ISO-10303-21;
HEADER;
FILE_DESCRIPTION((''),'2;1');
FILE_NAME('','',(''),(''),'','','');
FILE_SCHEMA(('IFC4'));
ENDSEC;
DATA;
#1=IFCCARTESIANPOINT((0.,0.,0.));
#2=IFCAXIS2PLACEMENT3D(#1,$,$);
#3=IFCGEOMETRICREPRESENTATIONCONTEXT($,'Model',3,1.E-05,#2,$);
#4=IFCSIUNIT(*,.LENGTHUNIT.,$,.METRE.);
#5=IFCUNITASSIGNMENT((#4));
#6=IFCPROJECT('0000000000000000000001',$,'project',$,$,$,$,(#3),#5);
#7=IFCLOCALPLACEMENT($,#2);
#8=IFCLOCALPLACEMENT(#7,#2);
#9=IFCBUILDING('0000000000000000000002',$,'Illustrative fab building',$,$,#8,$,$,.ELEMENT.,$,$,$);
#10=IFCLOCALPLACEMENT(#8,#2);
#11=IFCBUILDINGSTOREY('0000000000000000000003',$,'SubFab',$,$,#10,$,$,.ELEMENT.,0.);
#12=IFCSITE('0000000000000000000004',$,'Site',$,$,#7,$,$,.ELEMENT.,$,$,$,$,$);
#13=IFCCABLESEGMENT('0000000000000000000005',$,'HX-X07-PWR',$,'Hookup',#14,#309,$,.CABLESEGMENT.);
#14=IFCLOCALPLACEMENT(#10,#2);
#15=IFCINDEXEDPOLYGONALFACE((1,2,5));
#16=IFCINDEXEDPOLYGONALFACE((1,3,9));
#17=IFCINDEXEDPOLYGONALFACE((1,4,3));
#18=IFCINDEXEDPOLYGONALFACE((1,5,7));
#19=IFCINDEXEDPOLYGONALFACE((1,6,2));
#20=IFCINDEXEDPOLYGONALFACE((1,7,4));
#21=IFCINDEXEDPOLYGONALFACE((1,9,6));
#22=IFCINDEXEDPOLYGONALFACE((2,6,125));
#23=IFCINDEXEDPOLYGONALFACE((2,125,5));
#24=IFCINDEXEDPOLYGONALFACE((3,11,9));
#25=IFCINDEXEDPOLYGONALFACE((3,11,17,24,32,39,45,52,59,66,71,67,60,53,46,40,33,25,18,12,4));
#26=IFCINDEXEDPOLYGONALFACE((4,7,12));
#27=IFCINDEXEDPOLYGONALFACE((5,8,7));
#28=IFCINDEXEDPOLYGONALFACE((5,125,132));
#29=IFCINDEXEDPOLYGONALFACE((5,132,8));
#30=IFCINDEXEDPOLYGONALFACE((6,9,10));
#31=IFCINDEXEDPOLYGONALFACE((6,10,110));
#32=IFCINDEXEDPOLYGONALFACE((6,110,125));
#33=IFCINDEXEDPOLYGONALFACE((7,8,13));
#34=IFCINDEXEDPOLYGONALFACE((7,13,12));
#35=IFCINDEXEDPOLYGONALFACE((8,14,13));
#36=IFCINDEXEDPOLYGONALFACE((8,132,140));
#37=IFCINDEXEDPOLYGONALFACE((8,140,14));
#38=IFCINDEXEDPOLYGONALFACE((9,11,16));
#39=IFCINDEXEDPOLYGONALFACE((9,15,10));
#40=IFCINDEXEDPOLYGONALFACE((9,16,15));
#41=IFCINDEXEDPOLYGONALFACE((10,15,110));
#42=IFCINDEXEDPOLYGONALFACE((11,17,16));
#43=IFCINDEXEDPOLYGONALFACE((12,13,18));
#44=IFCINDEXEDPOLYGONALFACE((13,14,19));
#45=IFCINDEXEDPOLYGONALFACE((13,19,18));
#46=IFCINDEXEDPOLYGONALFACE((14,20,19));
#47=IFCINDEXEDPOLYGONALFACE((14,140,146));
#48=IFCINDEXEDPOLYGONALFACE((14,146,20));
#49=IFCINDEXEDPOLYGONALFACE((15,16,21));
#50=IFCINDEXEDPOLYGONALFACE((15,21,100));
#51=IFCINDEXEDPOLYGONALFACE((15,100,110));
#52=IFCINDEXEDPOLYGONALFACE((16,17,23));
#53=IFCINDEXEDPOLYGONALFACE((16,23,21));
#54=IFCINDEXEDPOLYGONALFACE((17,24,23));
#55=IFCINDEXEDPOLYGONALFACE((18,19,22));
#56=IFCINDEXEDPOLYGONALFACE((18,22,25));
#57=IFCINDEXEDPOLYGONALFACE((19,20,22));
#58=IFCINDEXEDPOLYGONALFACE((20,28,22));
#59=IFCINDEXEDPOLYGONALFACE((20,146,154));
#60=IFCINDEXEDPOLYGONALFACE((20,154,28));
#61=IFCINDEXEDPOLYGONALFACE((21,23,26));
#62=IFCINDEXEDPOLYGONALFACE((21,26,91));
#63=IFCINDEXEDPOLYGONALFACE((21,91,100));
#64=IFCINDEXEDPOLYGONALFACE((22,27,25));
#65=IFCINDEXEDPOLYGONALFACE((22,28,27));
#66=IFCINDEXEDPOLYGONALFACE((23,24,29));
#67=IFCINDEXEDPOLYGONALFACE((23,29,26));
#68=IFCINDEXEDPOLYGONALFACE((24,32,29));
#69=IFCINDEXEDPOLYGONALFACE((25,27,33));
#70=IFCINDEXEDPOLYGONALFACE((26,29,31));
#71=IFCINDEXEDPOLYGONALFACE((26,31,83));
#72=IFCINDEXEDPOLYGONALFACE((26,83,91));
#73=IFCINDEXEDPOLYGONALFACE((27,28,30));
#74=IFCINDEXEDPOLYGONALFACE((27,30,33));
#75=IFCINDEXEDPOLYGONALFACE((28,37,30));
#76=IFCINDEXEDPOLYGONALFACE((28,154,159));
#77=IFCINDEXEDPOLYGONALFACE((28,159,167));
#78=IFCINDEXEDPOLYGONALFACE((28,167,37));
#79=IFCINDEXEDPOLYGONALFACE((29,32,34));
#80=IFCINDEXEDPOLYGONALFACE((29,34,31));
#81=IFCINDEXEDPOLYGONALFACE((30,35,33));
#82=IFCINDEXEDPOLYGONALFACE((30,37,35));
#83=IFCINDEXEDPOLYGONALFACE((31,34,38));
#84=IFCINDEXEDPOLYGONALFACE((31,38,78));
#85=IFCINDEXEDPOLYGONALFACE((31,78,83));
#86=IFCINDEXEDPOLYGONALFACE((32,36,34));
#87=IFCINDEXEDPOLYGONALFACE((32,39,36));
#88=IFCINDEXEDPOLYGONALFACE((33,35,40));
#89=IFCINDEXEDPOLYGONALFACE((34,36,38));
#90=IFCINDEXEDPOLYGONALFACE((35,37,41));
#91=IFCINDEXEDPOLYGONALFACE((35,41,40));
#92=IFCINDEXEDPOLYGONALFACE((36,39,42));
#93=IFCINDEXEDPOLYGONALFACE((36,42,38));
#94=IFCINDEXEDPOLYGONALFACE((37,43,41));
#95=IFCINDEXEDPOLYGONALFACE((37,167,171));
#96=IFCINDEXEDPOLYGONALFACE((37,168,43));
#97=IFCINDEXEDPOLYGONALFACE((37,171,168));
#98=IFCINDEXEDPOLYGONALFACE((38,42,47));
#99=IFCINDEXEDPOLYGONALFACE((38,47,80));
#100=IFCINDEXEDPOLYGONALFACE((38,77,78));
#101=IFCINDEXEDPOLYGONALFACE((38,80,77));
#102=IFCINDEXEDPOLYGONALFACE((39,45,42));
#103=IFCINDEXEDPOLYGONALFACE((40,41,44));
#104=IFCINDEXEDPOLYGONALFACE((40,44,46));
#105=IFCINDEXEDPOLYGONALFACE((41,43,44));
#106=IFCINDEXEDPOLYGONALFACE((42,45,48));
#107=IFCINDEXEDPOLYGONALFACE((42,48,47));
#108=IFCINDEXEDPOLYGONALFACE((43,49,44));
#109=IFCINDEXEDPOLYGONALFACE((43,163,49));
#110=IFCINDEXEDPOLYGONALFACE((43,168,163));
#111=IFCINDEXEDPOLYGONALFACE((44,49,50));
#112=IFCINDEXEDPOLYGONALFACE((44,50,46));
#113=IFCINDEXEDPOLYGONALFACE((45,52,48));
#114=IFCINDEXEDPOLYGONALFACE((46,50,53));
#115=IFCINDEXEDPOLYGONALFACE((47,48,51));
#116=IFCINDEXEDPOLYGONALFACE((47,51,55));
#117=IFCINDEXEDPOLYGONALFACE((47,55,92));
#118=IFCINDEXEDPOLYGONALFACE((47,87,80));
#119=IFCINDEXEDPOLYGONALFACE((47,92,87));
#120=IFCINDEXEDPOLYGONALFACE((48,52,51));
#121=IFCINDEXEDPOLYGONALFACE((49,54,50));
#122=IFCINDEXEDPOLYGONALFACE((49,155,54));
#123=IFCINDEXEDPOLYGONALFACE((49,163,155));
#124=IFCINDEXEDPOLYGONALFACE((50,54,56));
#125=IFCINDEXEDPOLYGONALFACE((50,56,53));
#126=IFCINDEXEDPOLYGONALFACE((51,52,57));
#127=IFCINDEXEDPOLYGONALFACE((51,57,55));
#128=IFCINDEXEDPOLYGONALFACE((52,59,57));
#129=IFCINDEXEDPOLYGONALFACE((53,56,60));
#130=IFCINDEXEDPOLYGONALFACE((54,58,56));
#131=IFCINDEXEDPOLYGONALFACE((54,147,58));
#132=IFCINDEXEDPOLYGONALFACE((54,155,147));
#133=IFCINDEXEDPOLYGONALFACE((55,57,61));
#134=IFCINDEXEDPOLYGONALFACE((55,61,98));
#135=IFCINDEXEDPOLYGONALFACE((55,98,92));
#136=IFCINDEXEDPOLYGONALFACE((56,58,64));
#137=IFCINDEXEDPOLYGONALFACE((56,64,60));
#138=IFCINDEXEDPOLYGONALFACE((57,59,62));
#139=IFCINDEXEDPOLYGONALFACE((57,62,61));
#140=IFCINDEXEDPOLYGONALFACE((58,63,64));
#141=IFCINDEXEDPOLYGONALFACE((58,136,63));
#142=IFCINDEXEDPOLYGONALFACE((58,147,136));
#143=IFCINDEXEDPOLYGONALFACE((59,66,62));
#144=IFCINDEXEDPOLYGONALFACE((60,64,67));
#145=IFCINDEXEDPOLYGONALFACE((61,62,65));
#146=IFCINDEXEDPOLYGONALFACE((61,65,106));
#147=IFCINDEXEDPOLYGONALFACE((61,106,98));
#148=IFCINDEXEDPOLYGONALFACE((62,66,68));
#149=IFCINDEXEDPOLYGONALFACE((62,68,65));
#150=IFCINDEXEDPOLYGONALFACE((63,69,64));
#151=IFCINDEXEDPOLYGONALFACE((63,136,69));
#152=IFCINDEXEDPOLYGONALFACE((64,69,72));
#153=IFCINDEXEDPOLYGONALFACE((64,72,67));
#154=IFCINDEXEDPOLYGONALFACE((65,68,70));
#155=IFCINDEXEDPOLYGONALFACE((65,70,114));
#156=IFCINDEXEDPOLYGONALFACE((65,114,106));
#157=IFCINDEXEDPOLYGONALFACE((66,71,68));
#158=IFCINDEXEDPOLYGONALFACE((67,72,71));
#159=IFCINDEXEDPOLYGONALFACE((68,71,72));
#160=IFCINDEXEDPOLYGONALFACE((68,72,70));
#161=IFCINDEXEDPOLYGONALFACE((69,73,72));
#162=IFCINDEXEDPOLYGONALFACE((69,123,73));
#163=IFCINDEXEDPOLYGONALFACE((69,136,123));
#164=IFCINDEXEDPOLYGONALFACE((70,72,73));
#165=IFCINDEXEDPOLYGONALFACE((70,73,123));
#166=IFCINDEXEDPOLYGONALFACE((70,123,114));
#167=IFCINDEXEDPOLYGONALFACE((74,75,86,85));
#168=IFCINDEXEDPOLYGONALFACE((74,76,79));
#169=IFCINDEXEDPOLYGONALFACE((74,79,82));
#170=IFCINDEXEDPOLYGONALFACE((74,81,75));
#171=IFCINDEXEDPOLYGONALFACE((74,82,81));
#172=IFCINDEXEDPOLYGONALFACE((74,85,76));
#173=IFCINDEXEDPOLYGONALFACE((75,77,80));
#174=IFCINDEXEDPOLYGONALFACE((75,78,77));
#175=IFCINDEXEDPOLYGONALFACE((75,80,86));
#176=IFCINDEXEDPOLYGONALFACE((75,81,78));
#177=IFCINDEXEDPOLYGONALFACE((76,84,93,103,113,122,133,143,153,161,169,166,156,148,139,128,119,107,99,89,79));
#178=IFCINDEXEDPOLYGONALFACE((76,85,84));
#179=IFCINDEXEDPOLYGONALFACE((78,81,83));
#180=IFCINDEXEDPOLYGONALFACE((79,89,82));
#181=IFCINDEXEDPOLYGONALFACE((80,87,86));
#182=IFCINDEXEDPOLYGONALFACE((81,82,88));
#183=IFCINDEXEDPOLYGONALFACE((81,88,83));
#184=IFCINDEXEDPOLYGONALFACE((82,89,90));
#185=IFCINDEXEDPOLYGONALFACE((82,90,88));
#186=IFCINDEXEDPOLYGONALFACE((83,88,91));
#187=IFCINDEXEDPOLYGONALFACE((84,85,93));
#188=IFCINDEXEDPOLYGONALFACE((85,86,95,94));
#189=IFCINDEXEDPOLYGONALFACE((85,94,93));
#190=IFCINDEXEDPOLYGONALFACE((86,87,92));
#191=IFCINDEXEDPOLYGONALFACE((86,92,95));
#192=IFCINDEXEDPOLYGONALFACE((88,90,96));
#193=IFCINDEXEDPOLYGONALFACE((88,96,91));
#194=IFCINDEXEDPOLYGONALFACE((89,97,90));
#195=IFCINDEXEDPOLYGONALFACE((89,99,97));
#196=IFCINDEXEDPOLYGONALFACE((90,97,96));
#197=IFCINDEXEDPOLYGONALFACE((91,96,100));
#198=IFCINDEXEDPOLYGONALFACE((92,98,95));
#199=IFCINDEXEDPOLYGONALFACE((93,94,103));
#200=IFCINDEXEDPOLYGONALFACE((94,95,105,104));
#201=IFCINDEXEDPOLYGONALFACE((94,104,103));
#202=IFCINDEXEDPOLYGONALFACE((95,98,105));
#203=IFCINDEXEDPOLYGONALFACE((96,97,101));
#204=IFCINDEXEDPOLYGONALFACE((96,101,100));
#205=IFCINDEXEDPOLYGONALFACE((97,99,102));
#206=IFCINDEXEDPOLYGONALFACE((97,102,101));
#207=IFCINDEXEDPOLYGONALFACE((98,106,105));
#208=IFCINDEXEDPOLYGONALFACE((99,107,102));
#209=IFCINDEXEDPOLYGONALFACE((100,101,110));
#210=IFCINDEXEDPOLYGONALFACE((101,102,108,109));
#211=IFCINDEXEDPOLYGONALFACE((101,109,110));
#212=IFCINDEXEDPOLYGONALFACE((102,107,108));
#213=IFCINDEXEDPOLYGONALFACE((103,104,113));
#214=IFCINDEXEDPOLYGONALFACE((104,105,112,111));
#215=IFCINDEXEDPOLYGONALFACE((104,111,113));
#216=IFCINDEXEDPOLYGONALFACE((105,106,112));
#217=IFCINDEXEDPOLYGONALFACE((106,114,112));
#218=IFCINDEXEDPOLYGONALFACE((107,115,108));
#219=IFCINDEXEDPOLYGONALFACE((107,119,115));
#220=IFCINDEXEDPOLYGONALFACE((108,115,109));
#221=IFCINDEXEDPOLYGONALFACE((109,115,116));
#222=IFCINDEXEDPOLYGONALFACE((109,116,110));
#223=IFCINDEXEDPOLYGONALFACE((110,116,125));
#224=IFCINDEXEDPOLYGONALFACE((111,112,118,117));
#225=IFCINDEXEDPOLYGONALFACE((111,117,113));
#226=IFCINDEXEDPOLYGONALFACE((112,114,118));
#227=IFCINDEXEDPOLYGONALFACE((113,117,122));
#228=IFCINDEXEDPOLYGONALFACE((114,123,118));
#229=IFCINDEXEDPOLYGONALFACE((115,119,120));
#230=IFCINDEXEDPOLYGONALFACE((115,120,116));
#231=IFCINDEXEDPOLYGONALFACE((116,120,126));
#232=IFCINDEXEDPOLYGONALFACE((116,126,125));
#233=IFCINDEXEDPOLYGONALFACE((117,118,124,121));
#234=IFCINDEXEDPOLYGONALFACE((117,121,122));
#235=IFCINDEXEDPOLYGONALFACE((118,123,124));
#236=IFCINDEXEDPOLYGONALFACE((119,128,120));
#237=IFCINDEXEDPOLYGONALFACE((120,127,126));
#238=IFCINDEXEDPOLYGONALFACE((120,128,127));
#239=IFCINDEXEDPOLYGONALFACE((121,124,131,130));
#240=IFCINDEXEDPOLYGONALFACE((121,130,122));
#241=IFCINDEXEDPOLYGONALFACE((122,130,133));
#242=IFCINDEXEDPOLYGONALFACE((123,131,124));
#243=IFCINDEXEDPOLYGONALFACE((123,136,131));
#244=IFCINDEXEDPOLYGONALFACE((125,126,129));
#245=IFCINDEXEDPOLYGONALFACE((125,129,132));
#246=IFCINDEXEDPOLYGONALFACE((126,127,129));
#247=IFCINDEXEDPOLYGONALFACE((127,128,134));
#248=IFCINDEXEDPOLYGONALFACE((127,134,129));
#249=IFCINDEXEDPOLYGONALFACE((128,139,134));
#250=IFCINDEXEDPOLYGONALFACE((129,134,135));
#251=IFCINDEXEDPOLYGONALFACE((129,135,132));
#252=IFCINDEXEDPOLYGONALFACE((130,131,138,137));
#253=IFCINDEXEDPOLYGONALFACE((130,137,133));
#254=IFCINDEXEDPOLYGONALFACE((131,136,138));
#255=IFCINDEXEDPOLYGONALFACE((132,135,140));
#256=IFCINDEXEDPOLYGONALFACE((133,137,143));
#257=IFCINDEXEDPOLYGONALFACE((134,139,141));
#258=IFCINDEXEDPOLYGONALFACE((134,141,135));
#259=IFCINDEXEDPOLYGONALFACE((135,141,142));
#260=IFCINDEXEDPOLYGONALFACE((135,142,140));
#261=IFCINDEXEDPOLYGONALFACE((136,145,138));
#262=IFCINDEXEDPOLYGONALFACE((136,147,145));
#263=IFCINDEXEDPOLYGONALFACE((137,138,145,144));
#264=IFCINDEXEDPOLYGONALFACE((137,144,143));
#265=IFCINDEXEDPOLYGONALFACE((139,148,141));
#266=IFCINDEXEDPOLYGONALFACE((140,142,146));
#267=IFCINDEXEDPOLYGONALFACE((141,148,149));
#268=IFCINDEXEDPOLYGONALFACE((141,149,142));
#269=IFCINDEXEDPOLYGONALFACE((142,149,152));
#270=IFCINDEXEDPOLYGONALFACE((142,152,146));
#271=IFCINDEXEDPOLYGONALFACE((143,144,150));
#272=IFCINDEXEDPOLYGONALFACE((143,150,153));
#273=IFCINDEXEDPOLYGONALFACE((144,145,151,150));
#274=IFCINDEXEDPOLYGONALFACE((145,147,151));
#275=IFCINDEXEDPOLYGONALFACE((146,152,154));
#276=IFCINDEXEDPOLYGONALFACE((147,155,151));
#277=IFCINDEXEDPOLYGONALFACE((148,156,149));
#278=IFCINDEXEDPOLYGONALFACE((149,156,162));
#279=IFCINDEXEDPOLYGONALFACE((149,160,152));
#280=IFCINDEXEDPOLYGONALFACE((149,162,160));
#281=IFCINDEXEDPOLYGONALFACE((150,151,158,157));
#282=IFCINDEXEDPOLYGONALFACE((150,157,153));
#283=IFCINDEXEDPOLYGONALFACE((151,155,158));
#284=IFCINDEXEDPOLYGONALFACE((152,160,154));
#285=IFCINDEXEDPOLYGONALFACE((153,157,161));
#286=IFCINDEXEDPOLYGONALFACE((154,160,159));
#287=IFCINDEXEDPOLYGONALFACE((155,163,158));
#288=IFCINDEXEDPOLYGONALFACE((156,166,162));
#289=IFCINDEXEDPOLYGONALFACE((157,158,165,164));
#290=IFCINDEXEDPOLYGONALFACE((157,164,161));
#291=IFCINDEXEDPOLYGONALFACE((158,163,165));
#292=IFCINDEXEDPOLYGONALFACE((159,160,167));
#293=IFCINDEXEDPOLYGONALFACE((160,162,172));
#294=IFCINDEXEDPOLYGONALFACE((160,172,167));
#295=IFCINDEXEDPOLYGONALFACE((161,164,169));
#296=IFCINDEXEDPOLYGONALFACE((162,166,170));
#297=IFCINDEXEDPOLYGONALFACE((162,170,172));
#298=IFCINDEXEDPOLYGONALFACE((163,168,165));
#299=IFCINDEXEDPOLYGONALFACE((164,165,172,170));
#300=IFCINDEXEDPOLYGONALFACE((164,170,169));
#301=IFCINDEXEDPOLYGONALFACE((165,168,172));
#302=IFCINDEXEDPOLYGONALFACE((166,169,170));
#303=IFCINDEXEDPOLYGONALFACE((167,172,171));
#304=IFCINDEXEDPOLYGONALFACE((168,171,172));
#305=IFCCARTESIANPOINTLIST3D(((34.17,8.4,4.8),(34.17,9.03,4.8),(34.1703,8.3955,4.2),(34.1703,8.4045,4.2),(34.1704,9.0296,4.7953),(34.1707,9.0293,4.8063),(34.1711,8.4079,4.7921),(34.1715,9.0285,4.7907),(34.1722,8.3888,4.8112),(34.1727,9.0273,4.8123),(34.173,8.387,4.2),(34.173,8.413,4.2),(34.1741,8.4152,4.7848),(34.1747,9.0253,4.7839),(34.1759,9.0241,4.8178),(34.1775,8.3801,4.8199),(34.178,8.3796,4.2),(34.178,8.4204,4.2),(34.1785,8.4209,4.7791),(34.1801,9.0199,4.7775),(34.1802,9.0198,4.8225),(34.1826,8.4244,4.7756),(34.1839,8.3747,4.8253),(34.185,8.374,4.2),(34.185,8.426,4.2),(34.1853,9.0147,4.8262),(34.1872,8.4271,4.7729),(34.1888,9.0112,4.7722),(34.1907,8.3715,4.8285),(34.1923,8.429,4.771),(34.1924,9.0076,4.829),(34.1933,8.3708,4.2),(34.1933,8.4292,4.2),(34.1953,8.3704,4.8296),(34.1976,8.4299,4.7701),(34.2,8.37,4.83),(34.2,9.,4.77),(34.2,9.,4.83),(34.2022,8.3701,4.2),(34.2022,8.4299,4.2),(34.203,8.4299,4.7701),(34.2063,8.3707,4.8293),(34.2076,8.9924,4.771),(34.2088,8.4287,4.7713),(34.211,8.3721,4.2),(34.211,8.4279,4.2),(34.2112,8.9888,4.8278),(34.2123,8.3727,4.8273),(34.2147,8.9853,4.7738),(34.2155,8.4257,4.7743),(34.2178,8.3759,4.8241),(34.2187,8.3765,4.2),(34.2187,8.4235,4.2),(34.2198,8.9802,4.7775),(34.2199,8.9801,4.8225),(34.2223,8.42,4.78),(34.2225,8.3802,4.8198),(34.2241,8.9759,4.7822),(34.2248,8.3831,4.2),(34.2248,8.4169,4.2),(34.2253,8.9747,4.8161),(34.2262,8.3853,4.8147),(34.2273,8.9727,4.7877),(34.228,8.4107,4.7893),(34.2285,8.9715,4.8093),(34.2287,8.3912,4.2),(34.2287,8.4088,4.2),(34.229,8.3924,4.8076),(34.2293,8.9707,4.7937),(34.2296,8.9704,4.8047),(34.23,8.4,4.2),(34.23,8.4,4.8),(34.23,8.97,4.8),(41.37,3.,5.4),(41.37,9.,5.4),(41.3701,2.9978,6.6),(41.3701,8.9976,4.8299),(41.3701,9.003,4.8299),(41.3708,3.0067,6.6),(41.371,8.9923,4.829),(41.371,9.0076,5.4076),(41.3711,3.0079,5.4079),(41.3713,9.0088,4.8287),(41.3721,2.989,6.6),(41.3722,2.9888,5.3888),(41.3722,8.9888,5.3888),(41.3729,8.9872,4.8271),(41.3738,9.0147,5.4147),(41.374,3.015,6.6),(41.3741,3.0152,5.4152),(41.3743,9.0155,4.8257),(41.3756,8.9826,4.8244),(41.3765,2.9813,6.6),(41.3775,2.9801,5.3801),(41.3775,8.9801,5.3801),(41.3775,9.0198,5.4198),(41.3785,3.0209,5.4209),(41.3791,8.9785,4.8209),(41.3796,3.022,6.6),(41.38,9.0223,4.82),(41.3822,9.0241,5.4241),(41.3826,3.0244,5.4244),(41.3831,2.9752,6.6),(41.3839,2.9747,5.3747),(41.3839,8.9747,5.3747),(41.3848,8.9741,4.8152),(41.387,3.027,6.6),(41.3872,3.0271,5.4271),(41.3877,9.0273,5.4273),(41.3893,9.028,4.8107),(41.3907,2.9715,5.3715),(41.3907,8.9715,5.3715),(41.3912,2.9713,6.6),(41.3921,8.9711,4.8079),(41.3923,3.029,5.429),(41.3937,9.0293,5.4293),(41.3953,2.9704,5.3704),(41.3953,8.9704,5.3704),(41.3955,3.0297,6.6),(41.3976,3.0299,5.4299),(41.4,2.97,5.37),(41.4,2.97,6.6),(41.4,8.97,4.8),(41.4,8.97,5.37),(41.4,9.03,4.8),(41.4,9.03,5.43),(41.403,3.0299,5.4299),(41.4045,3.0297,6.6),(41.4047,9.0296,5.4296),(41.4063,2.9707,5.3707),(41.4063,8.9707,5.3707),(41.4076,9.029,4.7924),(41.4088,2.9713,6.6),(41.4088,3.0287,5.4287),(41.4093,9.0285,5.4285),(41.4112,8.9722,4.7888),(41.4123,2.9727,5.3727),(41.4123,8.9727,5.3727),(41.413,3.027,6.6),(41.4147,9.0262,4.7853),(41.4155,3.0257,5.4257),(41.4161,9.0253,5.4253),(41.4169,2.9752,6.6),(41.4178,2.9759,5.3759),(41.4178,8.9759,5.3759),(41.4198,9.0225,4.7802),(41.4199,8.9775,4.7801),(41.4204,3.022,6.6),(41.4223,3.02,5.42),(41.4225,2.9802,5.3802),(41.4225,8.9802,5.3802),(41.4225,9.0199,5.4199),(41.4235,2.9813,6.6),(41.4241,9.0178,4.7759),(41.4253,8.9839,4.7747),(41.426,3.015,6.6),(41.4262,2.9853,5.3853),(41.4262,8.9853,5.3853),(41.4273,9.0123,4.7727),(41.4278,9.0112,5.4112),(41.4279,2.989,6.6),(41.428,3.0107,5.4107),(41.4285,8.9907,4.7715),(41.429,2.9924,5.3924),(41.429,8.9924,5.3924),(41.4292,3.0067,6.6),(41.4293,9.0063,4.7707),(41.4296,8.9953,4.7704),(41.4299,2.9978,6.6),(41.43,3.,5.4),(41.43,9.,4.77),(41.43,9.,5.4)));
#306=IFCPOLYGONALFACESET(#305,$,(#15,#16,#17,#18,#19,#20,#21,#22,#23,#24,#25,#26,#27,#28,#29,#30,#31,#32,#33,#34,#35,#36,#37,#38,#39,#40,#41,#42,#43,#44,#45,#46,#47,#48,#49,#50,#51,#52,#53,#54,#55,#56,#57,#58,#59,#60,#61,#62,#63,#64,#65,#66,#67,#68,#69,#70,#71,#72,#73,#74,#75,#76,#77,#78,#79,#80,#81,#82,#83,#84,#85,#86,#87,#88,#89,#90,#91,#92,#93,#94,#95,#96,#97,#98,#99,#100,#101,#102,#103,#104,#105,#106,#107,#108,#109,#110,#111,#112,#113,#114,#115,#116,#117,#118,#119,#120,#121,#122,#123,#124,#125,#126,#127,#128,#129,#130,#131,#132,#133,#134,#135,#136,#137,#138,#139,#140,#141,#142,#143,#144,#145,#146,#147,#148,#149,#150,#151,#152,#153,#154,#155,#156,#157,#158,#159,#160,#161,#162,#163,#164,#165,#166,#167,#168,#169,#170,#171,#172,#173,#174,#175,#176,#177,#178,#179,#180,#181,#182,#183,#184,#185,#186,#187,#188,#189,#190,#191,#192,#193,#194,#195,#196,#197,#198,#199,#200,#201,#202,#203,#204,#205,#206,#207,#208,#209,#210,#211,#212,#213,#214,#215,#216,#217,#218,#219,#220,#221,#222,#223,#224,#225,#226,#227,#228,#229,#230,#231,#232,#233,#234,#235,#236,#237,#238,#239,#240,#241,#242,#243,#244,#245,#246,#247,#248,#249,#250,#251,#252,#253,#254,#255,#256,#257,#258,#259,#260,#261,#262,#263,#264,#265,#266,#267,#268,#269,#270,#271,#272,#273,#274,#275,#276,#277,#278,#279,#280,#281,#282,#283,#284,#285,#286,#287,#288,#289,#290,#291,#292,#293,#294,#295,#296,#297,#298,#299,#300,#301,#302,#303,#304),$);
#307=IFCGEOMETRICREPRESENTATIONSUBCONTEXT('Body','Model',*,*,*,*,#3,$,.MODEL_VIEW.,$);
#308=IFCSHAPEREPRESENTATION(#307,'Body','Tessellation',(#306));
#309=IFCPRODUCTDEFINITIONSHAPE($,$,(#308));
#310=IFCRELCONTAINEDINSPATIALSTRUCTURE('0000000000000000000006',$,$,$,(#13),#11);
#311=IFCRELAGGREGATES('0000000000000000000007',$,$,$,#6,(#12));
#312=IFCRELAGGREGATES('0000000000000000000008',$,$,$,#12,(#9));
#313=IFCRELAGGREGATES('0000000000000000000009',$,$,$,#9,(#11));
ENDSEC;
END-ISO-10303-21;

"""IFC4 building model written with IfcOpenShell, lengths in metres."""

from ifc_helpers import new_model, entity, si_unit, origin, place, context, subcontext, project, spatial, element, save


model = new_model("IFC4")

# Units and contexts
model_context = context("Model", 3, precision=1e-05, world=origin())
body_context = subcontext(model_context, "Body", "Model", "MODEL_VIEW")
ifc_project = project(units=[si_unit("LENGTHUNIT", "METRE")], contexts=[model_context])

# Site, building, storey
site_placement = place(None, origin())
site = spatial("IfcSite", under=ifc_project, at=site_placement, Name="Site", CompositionType="ELEMENT")
building_placement = place(site_placement, origin())
building = spatial("IfcBuilding", under=site, at=building_placement, Name="Illustrative fab building", CompositionType="ELEMENT")
storey_placement = place(building_placement, origin())
storey = spatial("IfcBuildingStorey", under=building, at=storey_placement, Name="SubFab", CompositionType="ELEMENT", Elevation=0.0)

# Cable segment
cable_segment_1_placement = place(storey_placement, origin())
element("IfcCableSegment", 1, at=cable_segment_1_placement, inside=storey, Name="HX-X07-PWR", ObjectType="Hookup", PredefinedType="CABLESEGMENT", context=body_context, shape_type="AdvancedSweptSolid", body=[
    entity("IfcSweptDiskSolid", entity("IfcPolyline", [entity("IfcCartesianPoint", [34.2, 8.4, 4.2]), entity("IfcCartesianPoint", [34.2, 8.4, 4.8]), entity("IfcCartesianPoint", [34.2, 9.0, 4.8]), entity("IfcCartesianPoint", [41.4, 9.0, 4.8]), entity("IfcCartesianPoint", [41.4, 9.0, 5.4]), entity("IfcCartesianPoint", [41.4, 3.0, 5.4]), entity("IfcCartesianPoint", [41.4, 3.0, 6.6])]), 0.03),
])

save(model, "model.ifc")
